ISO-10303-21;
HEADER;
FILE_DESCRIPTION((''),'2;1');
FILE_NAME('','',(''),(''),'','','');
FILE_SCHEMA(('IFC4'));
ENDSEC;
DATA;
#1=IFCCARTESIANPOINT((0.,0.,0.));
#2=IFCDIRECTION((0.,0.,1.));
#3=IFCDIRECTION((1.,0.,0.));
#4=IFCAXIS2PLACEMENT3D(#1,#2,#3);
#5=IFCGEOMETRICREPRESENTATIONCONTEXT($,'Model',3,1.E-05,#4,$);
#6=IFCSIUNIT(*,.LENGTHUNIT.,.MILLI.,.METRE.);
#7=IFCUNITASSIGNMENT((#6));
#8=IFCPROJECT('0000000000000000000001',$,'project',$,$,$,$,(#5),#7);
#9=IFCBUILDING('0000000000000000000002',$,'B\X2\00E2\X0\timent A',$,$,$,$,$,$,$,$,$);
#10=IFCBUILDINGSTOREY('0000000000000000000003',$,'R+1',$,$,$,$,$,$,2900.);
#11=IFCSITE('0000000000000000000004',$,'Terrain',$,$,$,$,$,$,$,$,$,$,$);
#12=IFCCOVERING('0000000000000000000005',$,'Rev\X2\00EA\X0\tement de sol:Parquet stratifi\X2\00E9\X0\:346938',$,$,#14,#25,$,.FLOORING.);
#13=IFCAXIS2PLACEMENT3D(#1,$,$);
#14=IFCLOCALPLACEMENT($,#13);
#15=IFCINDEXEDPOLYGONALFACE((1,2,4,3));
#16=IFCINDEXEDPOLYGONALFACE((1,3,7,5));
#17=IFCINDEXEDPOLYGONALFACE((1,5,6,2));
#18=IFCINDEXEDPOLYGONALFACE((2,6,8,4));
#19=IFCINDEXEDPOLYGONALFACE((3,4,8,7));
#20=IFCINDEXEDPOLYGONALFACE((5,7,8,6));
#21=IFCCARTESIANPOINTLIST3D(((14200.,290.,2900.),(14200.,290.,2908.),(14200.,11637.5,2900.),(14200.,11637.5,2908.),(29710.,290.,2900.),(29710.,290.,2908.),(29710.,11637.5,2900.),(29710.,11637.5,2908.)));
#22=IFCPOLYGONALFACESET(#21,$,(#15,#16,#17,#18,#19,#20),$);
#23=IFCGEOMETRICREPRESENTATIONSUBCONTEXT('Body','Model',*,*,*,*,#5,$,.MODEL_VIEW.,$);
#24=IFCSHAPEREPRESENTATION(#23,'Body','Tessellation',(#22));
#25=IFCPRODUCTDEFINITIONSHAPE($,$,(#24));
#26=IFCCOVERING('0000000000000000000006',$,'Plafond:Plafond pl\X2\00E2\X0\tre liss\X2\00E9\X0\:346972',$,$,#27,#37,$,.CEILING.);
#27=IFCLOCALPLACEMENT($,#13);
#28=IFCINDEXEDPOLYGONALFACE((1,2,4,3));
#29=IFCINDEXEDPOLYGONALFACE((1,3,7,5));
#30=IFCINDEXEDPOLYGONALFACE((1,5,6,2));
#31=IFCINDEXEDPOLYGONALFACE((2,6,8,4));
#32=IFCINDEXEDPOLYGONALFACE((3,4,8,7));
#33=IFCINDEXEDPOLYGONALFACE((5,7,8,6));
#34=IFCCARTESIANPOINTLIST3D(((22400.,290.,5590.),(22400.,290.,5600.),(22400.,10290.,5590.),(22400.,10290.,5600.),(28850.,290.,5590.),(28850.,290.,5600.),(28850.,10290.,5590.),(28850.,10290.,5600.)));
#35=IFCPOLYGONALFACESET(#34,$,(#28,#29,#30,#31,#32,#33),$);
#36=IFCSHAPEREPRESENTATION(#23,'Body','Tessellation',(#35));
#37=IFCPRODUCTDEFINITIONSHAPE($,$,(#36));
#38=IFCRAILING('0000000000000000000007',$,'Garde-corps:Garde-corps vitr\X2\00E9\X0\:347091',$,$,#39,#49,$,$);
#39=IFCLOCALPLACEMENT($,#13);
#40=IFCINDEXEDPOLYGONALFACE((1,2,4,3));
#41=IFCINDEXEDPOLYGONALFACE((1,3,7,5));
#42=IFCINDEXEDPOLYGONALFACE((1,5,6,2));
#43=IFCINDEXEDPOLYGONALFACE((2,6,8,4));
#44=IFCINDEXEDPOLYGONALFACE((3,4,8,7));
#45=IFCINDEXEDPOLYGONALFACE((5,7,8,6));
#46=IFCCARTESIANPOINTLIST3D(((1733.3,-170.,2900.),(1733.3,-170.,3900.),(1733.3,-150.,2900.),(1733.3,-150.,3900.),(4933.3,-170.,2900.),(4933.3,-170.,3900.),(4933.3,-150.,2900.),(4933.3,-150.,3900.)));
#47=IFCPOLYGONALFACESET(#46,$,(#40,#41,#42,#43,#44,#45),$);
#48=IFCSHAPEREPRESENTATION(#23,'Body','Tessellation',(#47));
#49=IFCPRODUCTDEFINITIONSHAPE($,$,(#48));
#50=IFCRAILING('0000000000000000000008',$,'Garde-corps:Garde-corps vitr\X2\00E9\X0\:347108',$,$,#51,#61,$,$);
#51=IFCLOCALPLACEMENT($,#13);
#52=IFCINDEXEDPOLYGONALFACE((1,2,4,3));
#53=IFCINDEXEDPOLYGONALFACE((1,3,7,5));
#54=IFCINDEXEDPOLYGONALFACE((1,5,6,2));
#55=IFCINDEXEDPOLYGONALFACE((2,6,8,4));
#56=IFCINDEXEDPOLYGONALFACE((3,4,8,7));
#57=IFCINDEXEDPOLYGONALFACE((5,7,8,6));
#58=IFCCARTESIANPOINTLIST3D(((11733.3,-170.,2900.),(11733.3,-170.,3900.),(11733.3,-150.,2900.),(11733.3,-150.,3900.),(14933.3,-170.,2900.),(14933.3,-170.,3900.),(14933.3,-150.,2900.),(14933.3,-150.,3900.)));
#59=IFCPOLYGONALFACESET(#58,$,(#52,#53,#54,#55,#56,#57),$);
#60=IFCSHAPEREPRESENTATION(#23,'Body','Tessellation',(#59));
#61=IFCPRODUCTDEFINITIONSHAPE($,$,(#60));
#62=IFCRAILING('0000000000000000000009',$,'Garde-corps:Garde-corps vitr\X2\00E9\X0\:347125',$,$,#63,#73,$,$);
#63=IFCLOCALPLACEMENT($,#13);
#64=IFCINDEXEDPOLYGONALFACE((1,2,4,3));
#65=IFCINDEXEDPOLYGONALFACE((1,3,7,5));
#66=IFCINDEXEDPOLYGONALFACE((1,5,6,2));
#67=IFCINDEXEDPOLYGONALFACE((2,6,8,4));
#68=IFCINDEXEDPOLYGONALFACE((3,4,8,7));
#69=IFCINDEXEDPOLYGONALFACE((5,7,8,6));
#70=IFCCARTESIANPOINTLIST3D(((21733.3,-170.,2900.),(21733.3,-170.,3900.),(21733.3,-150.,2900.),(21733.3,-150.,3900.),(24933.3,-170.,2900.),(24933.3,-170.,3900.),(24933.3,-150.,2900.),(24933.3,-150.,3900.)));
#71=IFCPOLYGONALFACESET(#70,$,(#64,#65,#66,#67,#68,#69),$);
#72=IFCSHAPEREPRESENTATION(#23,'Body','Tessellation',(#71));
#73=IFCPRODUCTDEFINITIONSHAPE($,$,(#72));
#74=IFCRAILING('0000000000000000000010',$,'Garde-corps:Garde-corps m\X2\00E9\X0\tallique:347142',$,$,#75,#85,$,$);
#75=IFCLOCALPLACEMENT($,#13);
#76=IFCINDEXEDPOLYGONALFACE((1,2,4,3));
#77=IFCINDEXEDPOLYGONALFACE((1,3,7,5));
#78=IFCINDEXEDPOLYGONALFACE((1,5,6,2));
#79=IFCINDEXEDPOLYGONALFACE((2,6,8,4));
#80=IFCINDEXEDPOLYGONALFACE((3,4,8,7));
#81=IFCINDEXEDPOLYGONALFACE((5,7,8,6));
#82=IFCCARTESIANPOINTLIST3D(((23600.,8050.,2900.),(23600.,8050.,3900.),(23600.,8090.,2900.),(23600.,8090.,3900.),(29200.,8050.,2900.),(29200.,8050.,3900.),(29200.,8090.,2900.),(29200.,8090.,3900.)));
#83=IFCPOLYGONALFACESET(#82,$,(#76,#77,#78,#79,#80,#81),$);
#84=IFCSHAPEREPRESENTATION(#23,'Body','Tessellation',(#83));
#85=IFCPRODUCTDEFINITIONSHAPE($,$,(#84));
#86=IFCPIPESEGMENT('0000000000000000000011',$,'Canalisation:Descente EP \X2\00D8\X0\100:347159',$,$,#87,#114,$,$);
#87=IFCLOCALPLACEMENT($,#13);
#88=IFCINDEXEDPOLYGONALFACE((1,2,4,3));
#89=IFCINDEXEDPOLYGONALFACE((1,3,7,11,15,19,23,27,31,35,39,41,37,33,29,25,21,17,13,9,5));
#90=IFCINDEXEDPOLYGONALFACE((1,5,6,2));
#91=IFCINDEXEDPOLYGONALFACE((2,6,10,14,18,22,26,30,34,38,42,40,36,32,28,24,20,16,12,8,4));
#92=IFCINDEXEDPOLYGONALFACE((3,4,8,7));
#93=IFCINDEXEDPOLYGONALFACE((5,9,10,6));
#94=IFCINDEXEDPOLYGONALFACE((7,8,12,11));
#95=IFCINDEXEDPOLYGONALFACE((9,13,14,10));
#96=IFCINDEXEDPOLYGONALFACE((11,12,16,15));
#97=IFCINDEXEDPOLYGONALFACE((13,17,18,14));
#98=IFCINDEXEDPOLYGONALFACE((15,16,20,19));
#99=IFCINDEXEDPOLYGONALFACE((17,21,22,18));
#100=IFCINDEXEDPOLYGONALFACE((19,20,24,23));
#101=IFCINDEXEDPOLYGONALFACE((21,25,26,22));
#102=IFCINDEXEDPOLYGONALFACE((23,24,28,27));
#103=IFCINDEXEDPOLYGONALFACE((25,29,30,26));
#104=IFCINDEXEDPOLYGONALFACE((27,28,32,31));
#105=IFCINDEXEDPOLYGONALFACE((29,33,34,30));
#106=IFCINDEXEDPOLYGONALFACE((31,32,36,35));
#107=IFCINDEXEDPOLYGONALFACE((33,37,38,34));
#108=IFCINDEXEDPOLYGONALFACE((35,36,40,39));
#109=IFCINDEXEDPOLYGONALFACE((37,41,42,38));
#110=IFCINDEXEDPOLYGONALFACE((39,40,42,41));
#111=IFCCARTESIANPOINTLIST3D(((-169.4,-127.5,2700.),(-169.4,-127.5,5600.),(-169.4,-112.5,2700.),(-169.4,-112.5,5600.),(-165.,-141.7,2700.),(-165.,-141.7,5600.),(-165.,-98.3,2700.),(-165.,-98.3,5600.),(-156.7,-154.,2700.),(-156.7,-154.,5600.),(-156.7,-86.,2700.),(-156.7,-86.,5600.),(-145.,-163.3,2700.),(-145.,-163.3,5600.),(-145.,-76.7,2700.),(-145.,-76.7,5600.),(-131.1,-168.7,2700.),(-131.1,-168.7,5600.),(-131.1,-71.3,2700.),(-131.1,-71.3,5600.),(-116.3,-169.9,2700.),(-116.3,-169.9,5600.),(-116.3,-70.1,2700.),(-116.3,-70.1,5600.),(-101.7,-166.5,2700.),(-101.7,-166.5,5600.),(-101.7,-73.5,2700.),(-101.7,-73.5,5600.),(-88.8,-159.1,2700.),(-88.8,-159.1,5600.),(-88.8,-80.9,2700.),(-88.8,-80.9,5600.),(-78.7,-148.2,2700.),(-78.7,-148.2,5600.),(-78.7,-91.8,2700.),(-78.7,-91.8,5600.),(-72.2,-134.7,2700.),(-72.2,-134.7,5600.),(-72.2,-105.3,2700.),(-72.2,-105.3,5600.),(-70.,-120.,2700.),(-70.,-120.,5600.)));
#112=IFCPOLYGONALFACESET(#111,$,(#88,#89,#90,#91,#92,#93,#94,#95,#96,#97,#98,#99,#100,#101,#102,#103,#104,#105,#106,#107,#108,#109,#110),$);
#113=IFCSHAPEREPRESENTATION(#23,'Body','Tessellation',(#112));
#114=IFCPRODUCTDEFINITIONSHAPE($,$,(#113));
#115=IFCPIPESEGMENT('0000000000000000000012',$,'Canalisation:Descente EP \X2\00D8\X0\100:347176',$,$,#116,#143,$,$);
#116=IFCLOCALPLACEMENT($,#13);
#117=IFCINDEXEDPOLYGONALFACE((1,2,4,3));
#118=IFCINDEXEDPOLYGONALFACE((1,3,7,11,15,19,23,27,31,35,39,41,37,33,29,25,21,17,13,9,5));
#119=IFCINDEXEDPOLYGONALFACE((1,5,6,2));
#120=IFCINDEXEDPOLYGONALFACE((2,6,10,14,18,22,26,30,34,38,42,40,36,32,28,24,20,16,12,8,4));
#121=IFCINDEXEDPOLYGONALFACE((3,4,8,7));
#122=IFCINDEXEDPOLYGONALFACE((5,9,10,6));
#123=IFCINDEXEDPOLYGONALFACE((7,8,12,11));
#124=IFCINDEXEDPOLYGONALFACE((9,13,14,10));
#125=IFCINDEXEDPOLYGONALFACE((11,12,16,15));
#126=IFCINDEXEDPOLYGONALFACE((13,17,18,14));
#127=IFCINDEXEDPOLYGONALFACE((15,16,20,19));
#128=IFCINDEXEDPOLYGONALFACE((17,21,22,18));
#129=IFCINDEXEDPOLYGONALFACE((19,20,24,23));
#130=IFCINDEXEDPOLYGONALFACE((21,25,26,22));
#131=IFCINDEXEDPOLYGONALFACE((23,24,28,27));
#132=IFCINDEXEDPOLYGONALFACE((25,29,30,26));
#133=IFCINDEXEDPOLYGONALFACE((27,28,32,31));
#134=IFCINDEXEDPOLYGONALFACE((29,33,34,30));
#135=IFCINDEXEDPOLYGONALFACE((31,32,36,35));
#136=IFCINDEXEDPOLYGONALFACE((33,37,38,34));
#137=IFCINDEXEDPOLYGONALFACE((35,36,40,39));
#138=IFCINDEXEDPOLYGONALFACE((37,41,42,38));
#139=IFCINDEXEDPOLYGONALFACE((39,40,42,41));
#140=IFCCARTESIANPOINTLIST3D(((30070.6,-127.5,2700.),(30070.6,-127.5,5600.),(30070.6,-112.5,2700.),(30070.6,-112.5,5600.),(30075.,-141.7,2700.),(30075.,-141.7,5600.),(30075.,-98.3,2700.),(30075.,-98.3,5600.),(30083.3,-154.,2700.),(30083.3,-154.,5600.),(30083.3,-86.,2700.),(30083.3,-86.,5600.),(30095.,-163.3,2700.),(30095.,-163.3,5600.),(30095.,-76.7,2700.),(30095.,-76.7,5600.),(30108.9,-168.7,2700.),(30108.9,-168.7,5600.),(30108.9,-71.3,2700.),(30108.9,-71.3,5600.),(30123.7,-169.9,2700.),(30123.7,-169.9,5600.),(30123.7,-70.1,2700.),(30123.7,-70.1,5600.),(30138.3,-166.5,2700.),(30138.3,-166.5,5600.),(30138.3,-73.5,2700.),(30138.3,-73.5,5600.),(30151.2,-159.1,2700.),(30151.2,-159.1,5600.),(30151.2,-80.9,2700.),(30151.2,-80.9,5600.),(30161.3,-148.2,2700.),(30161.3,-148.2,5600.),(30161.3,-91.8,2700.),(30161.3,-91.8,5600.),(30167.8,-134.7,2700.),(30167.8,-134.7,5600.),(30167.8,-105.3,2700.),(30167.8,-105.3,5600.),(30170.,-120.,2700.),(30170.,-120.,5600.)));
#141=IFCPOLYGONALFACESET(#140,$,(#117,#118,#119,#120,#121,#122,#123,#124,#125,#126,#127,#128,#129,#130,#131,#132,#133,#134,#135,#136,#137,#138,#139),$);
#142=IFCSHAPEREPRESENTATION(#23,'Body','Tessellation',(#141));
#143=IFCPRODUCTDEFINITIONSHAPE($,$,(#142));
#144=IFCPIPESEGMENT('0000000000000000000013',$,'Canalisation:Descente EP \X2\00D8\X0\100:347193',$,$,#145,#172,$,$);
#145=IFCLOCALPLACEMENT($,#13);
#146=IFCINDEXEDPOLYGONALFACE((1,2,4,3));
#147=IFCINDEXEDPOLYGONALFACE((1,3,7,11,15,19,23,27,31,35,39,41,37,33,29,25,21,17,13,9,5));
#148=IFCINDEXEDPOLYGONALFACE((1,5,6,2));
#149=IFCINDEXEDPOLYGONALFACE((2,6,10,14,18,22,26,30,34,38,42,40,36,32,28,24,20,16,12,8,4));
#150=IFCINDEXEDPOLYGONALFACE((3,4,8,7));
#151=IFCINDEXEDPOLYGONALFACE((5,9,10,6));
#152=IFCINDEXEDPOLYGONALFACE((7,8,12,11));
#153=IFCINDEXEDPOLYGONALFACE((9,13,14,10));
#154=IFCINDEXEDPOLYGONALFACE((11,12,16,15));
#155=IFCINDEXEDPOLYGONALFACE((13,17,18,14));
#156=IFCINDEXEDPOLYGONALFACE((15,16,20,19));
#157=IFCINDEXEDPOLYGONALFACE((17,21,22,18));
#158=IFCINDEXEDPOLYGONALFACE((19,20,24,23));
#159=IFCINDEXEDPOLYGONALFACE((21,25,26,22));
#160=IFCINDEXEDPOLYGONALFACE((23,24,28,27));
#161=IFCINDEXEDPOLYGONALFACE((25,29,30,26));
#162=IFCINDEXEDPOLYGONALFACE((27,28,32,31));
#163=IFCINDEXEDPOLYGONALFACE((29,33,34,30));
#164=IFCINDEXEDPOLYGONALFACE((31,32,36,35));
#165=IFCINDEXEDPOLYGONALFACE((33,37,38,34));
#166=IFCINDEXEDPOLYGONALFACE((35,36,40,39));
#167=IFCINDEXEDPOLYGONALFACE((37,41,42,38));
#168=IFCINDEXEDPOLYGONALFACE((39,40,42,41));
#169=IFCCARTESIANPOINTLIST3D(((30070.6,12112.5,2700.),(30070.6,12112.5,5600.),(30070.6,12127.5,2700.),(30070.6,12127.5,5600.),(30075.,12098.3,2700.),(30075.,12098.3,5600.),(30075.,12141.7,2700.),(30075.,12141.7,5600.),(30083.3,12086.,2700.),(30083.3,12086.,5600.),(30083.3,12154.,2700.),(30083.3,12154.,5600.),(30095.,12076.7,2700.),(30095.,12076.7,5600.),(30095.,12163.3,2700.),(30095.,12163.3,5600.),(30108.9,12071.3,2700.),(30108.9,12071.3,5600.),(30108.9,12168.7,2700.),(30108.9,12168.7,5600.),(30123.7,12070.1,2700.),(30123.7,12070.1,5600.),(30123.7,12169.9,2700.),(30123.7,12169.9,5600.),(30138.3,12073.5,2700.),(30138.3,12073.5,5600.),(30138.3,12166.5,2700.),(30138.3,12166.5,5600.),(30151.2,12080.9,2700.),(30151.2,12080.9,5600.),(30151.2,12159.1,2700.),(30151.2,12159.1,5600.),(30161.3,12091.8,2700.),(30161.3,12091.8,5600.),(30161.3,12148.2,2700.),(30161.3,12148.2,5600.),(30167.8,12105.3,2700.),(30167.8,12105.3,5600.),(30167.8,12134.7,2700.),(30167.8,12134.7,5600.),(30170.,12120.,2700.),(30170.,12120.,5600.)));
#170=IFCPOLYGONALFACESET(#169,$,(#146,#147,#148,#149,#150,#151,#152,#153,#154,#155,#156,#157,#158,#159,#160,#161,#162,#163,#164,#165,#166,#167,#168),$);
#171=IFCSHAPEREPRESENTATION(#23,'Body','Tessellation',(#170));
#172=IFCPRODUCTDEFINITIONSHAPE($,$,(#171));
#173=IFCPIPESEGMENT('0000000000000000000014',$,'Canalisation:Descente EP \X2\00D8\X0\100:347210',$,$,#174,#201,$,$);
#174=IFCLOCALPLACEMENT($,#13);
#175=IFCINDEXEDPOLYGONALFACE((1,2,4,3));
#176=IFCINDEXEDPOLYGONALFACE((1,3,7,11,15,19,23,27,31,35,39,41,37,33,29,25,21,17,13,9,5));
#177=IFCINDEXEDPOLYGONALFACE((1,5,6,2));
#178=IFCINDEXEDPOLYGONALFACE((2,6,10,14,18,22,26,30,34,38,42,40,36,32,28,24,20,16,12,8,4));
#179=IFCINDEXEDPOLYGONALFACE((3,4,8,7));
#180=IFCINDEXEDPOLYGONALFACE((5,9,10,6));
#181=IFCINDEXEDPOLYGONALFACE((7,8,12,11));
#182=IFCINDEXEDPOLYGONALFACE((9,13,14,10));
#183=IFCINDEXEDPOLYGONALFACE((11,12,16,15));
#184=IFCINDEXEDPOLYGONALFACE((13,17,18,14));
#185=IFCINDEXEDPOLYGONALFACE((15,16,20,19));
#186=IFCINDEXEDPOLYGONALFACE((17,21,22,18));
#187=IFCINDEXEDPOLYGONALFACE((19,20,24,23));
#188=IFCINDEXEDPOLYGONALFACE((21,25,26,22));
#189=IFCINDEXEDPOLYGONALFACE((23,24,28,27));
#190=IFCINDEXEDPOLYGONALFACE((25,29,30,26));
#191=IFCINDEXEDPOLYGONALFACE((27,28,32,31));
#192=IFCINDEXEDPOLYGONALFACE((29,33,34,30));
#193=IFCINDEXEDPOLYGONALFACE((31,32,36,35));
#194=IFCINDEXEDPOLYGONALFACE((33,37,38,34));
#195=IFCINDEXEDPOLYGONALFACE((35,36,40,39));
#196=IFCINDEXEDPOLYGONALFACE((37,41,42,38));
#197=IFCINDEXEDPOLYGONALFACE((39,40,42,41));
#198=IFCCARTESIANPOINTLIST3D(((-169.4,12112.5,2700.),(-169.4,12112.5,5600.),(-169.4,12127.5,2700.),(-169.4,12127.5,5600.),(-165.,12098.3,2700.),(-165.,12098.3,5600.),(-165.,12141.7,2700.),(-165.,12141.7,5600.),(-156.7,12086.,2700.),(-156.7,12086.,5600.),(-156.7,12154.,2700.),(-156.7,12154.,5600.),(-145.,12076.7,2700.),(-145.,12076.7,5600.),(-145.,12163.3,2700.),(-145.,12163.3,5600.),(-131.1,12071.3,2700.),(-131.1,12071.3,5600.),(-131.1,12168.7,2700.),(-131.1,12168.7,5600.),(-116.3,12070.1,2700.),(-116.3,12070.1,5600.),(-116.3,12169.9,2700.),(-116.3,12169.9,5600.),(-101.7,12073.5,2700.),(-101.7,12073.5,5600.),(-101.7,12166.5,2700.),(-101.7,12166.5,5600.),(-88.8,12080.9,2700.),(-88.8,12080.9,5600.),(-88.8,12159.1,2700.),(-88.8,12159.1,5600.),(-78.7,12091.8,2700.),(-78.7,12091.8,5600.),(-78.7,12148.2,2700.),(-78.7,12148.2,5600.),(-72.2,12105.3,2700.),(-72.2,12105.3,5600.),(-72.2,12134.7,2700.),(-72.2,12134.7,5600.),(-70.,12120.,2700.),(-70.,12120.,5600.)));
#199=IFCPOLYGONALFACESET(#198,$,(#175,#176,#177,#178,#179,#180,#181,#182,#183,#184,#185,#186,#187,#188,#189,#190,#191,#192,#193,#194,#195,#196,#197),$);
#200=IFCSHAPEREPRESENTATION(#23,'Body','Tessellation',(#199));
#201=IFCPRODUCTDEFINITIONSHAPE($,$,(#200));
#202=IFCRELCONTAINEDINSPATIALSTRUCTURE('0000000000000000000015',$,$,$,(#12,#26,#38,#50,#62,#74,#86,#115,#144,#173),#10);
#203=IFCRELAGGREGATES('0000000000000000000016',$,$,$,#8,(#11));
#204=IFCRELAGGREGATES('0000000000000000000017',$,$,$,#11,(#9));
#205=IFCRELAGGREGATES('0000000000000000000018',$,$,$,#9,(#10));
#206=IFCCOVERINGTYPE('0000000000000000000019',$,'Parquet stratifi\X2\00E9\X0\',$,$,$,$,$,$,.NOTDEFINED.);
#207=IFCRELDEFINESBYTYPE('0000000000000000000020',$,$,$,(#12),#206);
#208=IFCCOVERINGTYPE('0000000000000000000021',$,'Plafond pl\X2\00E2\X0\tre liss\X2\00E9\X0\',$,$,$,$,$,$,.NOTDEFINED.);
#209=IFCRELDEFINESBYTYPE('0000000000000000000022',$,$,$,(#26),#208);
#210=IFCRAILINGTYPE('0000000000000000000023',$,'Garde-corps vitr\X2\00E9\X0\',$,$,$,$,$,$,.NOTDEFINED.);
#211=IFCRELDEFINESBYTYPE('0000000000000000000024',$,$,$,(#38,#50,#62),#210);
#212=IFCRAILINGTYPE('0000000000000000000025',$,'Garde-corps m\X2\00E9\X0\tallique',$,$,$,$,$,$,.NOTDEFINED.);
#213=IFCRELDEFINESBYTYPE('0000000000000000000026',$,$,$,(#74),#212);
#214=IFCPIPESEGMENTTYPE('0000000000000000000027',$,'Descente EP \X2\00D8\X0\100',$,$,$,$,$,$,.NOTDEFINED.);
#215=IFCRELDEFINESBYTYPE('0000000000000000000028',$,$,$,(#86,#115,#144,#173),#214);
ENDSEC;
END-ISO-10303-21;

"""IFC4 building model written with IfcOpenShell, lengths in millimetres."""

from ifc_helpers import new_model, si_unit, frame, frame_2d, origin_with_axes, origin_2d, place, context, subcontext, project, spatial, rectangle, circle, extrude, type_object, element, save


model = new_model("IFC4")

# Units and contexts
model_context = context("Model", 3, precision=1e-05, world=origin_with_axes())
body_context = subcontext(model_context, "Body", "Model", "MODEL_VIEW")
ifc_project = project(units=[si_unit("LENGTHUNIT", "METRE", prefix="MILLI")], contexts=[model_context])

# Site, building, storey
site = spatial("IfcSite", under=ifc_project, Name="Terrain")
building = spatial("IfcBuilding", under=site, Name="Bâtiment A")
storey = spatial("IfcBuildingStorey", under=building, Name="R+1", Elevation=2900.0)

# Coverings
covering_type_1 = type_object("IfcCoveringType", Name="Parquet stratifié", PredefinedType="NOTDEFINED")
covering_1_placement = place(None, origin_with_axes())
element("IfcCovering", 1, at=covering_1_placement, inside=storey, type_object=covering_type_1, Name="Revêtement de sol:Parquet stratifié:346938", PredefinedType="FLOORING", context=body_context, shape_type="SweptSolid", body=[
    extrude(rectangle(XDim=15510.0, YDim=11347.5, at=frame_2d((21955.0, 5963.8))), frame((0.0, 0.0, 2900.0), z_axis=(0.0, 0.0, 1.0), x_axis=(1.0, 0.0, 0.0)), (0.0, 0.0, 1.0), 8.0),
])
covering_type_2 = type_object("IfcCoveringType", Name="Plafond plâtre lissé", PredefinedType="NOTDEFINED")
covering_2_placement = place(None, origin_with_axes())
element("IfcCovering", 2, at=covering_2_placement, inside=storey, type_object=covering_type_2, Name="Plafond:Plafond plâtre lissé:346972", PredefinedType="CEILING", context=body_context, shape_type="SweptSolid", body=[
    extrude(rectangle(XDim=6450.0, YDim=10000.0, at=frame_2d((25625.0, 5290.0))), frame((0.0, 0.0, 5590.0), z_axis=(0.0, 0.0, 1.0), x_axis=(1.0, 0.0, 0.0)), (0.0, 0.0, 1.0), 10.0),
])

# Railings
railing_type_1 = type_object("IfcRailingType", Name="Garde-corps vitré", PredefinedType="NOTDEFINED")
railing_1_placement = place(None, origin_with_axes())
element("IfcRailing", 3, at=railing_1_placement, inside=storey, type_object=railing_type_1, Name="Garde-corps:Garde-corps vitré:347091", context=body_context, shape_type="SweptSolid", body=[
    extrude(rectangle(XDim=3200.0, YDim=20.0, at=frame_2d((3333.3, -160.0))), frame((0.0, 0.0, 2900.0), z_axis=(0.0, 0.0, 1.0), x_axis=(1.0, 0.0, 0.0)), (0.0, 0.0, 1.0), 1000.0),
])
railing_2_placement = place(None, origin_with_axes())
element("IfcRailing", 4, at=railing_2_placement, inside=storey, type_object=railing_type_1, Name="Garde-corps:Garde-corps vitré:347108", context=body_context, shape_type="SweptSolid", body=[
    extrude(rectangle(XDim=3200.0, YDim=20.0, at=frame_2d((13333.3, -160.0))), frame((0.0, 0.0, 2900.0), z_axis=(0.0, 0.0, 1.0), x_axis=(1.0, 0.0, 0.0)), (0.0, 0.0, 1.0), 1000.0),
])
railing_3_placement = place(None, origin_with_axes())
element("IfcRailing", 5, at=railing_3_placement, inside=storey, type_object=railing_type_1, Name="Garde-corps:Garde-corps vitré:347125", context=body_context, shape_type="SweptSolid", body=[
    extrude(rectangle(XDim=3200.0, YDim=20.0, at=frame_2d((23333.3, -160.0))), frame((0.0, 0.0, 2900.0), z_axis=(0.0, 0.0, 1.0), x_axis=(1.0, 0.0, 0.0)), (0.0, 0.0, 1.0), 1000.0),
])
railing_type_2 = type_object("IfcRailingType", Name="Garde-corps métallique", PredefinedType="NOTDEFINED")
railing_4_placement = place(None, origin_with_axes())
element("IfcRailing", 6, at=railing_4_placement, inside=storey, type_object=railing_type_2, Name="Garde-corps:Garde-corps métallique:347142", context=body_context, shape_type="SweptSolid", body=[
    extrude(rectangle(XDim=5600.0, YDim=40.0, at=frame_2d((26400.0, 8070.0))), frame((0.0, 0.0, 2900.0), z_axis=(0.0, 0.0, 1.0), x_axis=(1.0, 0.0, 0.0)), (0.0, 0.0, 1.0), 1000.0),
])

# Pipe segments
pipe_segment_type = type_object("IfcPipeSegmentType", Name="Descente EP Ø100", PredefinedType="NOTDEFINED")
pipe_segment_1_placement = place(None, origin_with_axes())
element("IfcPipeSegment", 7, at=pipe_segment_1_placement, inside=storey, type_object=pipe_segment_type, Name="Canalisation:Descente EP Ø100:347159", context=body_context, shape_type="SweptSolid", body=[
    extrude(circle(Radius=50.0, at=origin_2d()), frame((-120.0, -120.0, 2700.0), z_axis=(0.0, 0.0, 1.0), x_axis=(1.0, 0.0, 0.0)), (0.0, 0.0, 1.0), 2900.0),
])
pipe_segment_2_placement = place(None, origin_with_axes())
element("IfcPipeSegment", 8, at=pipe_segment_2_placement, inside=storey, type_object=pipe_segment_type, Name="Canalisation:Descente EP Ø100:347176", context=body_context, shape_type="SweptSolid", body=[
    extrude(circle(Radius=50.0, at=origin_2d()), frame((30120.0, -120.0, 2700.0), z_axis=(0.0, 0.0, 1.0), x_axis=(1.0, 0.0, 0.0)), (0.0, 0.0, 1.0), 2900.0),
])
pipe_segment_3_placement = place(None, origin_with_axes())
element("IfcPipeSegment", 9, at=pipe_segment_3_placement, inside=storey, type_object=pipe_segment_type, Name="Canalisation:Descente EP Ø100:347193", context=body_context, shape_type="SweptSolid", body=[
    extrude(circle(Radius=50.0, at=origin_2d()), frame((30120.0, 12120.0, 2700.0), z_axis=(0.0, 0.0, 1.0), x_axis=(1.0, 0.0, 0.0)), (0.0, 0.0, 1.0), 2900.0),
])
pipe_segment_4_placement = place(None, origin_with_axes())
element("IfcPipeSegment", 10, at=pipe_segment_4_placement, inside=storey, type_object=pipe_segment_type, Name="Canalisation:Descente EP Ø100:347210", context=body_context, shape_type="SweptSolid", body=[
    extrude(circle(Radius=50.0, at=origin_2d()), frame((-120.0, 12120.0, 2700.0), z_axis=(0.0, 0.0, 1.0), x_axis=(1.0, 0.0, 0.0)), (0.0, 0.0, 1.0), 2900.0),
])

save(model, "model.ifc")
